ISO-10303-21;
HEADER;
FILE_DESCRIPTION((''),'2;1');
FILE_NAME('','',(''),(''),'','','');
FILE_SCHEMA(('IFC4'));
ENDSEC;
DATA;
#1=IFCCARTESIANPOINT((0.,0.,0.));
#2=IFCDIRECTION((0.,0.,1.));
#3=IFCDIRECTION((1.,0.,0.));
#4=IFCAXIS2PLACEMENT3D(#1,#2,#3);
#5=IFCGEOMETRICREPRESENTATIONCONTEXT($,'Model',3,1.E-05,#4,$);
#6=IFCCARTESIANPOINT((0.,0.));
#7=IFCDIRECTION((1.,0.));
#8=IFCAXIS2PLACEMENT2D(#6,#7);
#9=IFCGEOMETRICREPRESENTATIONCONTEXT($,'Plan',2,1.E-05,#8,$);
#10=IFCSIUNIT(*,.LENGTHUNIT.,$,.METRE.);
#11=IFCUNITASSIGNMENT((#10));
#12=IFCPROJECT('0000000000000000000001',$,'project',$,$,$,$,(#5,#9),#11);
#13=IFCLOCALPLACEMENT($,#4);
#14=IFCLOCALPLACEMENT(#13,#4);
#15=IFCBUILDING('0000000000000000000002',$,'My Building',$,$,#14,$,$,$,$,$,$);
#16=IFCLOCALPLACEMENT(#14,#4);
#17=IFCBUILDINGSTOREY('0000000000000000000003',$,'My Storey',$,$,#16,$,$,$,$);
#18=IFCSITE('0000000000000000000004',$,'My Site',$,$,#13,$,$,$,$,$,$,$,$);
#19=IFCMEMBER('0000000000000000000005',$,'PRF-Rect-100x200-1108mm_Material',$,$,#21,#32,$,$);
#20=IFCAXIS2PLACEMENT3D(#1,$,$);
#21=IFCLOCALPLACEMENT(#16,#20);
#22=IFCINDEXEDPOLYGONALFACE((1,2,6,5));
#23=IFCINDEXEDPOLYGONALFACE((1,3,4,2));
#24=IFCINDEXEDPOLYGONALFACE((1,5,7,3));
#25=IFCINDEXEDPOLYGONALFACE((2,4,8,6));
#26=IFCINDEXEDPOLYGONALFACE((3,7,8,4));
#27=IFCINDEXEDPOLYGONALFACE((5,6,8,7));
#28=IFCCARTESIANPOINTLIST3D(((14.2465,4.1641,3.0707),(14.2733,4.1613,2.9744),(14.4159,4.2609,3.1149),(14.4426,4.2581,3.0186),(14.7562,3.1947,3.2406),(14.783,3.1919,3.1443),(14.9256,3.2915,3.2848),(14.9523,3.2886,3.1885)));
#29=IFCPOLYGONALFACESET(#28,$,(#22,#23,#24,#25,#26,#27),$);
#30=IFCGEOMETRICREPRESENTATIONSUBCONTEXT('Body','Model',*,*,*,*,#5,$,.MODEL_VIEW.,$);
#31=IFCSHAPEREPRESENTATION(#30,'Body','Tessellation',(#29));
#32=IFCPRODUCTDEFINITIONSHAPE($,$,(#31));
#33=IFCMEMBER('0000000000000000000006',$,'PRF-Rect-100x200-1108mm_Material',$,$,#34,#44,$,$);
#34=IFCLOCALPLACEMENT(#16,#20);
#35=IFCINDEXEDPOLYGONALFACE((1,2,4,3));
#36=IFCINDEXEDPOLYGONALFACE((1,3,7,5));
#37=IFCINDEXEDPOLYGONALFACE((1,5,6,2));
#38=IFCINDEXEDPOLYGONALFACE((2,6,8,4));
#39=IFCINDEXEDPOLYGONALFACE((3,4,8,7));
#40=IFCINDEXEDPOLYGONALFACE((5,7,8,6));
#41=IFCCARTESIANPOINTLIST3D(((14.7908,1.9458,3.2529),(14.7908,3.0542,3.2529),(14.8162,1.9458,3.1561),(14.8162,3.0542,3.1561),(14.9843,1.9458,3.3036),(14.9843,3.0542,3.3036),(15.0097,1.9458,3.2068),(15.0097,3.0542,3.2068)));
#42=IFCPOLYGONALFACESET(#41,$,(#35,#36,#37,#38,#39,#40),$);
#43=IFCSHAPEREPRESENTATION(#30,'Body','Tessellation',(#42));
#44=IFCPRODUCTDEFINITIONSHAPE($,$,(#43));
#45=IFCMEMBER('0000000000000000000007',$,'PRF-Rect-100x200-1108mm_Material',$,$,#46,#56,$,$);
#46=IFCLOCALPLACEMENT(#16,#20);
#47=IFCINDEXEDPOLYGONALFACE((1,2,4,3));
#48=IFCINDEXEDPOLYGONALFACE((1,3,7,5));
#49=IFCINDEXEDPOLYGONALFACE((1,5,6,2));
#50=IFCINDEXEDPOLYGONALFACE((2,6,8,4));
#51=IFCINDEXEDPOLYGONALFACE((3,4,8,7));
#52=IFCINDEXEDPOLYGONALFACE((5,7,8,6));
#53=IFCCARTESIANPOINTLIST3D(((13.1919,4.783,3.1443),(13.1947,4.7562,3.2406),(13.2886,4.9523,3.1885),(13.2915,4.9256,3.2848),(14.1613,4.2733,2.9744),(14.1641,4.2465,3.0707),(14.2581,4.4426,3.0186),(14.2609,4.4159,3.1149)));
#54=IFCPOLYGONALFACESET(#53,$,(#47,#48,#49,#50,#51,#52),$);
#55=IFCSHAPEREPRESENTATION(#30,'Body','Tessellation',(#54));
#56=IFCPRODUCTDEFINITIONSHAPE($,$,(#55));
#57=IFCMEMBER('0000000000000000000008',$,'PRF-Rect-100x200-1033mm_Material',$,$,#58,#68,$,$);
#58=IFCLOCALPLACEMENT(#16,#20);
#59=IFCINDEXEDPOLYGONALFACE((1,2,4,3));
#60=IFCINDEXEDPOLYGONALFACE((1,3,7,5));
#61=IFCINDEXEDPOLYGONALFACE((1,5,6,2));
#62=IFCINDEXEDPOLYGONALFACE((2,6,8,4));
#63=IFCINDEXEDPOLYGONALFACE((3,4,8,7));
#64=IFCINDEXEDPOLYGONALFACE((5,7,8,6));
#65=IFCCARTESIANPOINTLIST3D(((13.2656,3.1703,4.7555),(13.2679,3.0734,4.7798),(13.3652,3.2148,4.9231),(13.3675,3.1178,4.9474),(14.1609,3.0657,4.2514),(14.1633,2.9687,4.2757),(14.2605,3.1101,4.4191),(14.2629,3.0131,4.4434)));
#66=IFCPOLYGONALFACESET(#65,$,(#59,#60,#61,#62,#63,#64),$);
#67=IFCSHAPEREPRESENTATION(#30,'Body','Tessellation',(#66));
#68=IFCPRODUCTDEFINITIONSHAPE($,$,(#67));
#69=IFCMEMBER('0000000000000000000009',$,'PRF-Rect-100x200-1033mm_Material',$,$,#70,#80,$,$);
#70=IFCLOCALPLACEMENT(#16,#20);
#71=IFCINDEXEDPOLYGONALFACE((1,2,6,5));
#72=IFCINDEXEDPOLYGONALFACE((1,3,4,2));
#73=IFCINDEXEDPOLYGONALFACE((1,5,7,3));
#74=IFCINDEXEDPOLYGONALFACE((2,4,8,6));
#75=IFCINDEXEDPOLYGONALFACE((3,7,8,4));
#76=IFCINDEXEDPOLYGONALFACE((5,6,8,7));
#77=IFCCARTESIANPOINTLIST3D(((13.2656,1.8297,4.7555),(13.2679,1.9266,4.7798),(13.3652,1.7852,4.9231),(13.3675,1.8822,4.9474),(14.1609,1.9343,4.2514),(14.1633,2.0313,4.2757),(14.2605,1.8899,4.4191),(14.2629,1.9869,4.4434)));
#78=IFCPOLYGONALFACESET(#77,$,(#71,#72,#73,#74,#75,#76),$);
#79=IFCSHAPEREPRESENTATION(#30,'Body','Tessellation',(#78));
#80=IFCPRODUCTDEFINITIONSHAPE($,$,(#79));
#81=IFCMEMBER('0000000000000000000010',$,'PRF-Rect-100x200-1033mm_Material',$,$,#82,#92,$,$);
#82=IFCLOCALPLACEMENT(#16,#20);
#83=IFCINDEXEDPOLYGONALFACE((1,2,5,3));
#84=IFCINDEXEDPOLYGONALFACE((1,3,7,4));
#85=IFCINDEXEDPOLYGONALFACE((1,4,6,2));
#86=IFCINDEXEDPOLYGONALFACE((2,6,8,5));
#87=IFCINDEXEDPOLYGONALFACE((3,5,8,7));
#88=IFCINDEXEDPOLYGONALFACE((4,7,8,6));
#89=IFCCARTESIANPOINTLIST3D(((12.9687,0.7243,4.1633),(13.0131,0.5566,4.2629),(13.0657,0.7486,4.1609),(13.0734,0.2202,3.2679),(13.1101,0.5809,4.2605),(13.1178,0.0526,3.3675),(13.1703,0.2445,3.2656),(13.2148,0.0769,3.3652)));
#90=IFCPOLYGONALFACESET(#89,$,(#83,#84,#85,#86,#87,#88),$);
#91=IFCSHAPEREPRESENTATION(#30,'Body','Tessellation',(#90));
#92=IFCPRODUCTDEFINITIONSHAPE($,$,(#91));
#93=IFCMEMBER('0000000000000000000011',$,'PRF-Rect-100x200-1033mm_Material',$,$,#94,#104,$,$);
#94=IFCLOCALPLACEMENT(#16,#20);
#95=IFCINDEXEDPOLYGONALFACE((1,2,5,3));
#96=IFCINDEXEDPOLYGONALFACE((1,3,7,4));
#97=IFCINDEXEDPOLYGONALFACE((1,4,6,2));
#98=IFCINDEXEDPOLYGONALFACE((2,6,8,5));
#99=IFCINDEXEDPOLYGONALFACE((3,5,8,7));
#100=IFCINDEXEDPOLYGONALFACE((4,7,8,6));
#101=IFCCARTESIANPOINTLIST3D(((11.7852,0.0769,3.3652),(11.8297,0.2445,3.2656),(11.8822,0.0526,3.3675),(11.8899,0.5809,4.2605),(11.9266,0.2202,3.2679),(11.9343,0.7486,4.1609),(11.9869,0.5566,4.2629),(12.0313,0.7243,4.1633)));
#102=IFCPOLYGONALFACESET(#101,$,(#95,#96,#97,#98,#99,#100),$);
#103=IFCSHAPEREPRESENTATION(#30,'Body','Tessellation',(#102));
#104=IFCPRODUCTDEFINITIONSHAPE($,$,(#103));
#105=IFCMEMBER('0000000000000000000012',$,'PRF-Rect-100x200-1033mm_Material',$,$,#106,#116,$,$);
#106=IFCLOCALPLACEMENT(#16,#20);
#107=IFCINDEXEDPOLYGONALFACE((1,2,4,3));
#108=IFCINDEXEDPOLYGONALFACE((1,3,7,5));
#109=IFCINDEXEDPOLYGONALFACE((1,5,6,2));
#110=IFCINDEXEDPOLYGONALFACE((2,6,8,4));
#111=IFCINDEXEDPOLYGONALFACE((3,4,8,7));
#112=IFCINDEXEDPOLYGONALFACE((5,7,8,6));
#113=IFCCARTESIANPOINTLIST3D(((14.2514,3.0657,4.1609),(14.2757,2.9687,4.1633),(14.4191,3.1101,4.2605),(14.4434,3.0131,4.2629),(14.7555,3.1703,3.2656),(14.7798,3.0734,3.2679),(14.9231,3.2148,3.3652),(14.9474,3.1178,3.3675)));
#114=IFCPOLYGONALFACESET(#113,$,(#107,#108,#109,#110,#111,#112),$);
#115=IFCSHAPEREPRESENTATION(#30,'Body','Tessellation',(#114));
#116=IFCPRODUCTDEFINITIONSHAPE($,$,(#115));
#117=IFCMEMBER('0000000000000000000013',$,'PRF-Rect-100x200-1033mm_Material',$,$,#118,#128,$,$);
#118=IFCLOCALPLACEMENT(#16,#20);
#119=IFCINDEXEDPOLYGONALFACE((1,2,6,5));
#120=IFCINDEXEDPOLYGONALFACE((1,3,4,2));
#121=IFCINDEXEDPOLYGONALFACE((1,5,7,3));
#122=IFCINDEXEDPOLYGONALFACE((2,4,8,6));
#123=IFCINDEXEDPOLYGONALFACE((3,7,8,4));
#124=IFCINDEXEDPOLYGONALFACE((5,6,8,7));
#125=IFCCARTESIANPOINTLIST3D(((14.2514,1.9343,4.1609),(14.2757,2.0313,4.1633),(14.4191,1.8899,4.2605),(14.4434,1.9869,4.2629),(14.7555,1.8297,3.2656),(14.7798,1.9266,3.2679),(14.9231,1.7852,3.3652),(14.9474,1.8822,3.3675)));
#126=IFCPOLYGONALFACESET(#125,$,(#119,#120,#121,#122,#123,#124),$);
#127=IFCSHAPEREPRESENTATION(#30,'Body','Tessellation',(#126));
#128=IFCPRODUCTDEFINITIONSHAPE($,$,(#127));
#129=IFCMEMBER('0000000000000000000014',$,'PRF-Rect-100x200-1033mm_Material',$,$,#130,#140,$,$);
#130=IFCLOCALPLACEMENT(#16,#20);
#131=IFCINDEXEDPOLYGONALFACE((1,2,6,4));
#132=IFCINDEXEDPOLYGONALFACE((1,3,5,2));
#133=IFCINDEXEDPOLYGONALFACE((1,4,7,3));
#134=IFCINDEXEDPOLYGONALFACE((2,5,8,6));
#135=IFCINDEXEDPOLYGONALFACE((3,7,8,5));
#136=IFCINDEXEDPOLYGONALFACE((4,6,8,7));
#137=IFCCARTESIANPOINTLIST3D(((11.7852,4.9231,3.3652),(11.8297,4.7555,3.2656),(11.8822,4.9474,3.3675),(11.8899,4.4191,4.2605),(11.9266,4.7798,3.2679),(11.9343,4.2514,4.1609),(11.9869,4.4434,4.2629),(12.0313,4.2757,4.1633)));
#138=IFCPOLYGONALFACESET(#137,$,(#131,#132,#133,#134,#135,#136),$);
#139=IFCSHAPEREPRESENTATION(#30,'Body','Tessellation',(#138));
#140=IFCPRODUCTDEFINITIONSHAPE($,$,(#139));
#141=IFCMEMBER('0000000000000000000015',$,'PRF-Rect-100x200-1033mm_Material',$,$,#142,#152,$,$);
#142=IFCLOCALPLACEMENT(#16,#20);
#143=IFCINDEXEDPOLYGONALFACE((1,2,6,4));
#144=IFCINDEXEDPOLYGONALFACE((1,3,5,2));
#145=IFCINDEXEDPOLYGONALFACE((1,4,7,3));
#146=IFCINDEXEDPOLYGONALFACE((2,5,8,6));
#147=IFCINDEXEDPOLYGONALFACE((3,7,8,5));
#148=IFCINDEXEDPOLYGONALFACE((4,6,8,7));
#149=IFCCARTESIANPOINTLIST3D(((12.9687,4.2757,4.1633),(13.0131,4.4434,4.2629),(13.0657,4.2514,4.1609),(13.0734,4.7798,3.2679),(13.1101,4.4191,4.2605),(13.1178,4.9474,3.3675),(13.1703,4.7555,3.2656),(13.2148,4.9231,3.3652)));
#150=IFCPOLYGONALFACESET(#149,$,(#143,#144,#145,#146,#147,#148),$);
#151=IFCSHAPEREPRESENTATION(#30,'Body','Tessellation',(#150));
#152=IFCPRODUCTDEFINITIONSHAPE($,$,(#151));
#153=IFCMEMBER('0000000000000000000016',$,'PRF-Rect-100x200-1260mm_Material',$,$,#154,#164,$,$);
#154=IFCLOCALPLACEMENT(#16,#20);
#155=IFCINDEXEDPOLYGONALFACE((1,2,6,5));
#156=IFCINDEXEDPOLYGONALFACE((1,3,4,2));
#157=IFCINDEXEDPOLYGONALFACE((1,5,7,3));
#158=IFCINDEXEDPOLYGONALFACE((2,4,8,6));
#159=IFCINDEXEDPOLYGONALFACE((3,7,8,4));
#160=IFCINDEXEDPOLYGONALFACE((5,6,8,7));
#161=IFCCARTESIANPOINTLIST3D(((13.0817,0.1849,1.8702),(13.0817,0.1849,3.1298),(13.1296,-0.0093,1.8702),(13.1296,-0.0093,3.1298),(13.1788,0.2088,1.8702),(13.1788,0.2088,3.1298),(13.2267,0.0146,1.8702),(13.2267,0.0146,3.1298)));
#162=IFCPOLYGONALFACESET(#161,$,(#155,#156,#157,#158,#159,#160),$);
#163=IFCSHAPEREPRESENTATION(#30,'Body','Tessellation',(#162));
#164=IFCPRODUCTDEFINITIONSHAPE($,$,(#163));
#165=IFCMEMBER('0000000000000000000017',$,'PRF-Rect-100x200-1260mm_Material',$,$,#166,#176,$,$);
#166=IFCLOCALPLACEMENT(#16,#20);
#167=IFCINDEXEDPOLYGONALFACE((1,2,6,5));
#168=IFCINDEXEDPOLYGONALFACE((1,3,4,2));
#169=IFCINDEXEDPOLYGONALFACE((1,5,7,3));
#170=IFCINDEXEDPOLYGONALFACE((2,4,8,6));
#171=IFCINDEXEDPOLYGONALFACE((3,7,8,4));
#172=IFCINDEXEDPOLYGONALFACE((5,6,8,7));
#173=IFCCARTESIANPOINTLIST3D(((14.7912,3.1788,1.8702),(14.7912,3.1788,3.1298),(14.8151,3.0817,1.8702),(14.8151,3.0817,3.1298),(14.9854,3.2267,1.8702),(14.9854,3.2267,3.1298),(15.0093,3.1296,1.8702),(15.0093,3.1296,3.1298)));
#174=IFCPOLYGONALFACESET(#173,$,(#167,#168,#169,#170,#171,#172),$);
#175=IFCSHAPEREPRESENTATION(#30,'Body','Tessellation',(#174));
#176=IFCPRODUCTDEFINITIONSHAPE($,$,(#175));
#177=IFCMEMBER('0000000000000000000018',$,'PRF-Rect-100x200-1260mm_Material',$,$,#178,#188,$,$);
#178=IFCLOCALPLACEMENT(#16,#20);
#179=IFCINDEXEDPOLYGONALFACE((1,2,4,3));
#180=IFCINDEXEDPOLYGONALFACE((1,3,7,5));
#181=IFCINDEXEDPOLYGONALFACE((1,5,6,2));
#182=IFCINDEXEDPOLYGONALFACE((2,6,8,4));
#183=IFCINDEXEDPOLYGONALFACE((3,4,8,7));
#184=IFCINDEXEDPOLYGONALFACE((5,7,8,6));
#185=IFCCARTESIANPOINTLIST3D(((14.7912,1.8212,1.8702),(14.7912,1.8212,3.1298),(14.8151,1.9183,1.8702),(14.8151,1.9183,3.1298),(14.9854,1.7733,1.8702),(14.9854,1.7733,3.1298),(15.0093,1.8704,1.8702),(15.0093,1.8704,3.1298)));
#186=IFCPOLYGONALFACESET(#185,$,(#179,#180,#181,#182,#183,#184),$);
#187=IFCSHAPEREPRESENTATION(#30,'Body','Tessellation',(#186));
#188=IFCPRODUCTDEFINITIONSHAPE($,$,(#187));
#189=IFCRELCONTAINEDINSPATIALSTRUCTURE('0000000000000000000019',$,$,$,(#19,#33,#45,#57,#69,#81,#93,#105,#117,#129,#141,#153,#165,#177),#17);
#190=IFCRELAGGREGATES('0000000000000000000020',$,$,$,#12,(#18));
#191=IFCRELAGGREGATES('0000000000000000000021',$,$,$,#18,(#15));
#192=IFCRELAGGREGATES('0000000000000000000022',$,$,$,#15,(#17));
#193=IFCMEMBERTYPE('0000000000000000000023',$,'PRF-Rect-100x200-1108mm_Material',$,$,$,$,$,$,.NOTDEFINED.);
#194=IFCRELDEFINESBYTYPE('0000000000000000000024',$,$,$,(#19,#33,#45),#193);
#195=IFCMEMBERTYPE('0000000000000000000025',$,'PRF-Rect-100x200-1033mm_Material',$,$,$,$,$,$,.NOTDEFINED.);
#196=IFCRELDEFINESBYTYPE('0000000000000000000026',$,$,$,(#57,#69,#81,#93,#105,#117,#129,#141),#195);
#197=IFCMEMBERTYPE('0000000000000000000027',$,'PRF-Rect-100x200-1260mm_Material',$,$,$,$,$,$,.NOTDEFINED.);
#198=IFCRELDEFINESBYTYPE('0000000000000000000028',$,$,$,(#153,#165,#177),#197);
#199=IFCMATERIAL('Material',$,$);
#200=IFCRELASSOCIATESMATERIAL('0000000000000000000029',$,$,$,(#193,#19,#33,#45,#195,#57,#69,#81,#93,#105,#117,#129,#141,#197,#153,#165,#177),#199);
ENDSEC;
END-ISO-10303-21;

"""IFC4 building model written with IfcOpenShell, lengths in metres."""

from ifc_helpers import new_model, si_unit, frame, origin, origin_with_axes, origin_2d_with_axis, place, context, subcontext, project, spatial, rectangle, extrude, material, material_profile, profile_set, profile_usage, type_object, element, save


model = new_model("IFC4")

# Units and contexts
model_context = context("Model", 3, precision=1e-05, world=origin_with_axes())
plan_context = context("Plan", 2, precision=1e-05, world=origin_2d_with_axis())
body_context = subcontext(model_context, "Body", "Model", "MODEL_VIEW")
ifc_project = project(units=[si_unit("LENGTHUNIT", "METRE")], contexts=[model_context, plan_context])

# Site, building, storey
site_placement = place(None, origin_with_axes())
site = spatial("IfcSite", under=ifc_project, at=site_placement, Name="My Site")
building_placement = place(site_placement, origin_with_axes())
building = spatial("IfcBuilding", under=site, at=building_placement, Name="My Building")
storey_placement = place(building_placement, origin_with_axes())
storey = spatial("IfcBuildingStorey", under=building, at=storey_placement, Name="My Storey")

# Members
ifc_material = material(Name="Material")
ifc_material_profile_1 = material_profile(ifc_material, rectangle(XDim=0.1, YDim=0.2))
ifc_profile_set_1 = profile_set([ifc_material_profile_1], Name="PRF-Rect-100x200-1108mm_Material")
member_type_1 = type_object("IfcMemberType", Name="PRF-Rect-100x200-1108mm_Material", PredefinedType="NOTDEFINED", material=ifc_profile_set_1)
ifc_profile_usage_1 = profile_usage(ifc_profile_set_1, cardinal=5)
member_1_placement = place(storey_placement, frame((14.3446, 4.2111, 3.0446), z_axis=(0.459849, -0.874668, 0.153283), x_axis=(0.2675, -0.028153, -0.963147)))
element("IfcMember", 1, at=member_1_placement, inside=storey, type_object=member_type_1, material=ifc_profile_usage_1, Name="PRF-Rect-100x200-1108mm_Material", context=body_context, shape_type="SweptSolid", body=[
    extrude(rectangle(XDim=0.1, YDim=0.2), origin(), (0.0, 0.0, 1.0), 1.1084),
])
ifc_profile_usage_2 = profile_usage(ifc_profile_set_1, cardinal=5)
member_2_placement = place(storey_placement, frame((14.9002, 3.0542, 3.2298), z_axis=(0.0, -1.0, 0.0), x_axis=(0.253569, 0.0, -0.967317)))
element("IfcMember", 2, at=member_2_placement, inside=storey, type_object=member_type_1, material=ifc_profile_usage_2, Name="PRF-Rect-100x200-1108mm_Material", context=body_context, shape_type="SweptSolid", body=[
    extrude(rectangle(XDim=0.1, YDim=0.2), origin(), (0.0, 0.0, 1.0), 1.1084),
])
ifc_profile_usage_3 = profile_usage(ifc_profile_set_1, cardinal=5)
member_3_placement = place(storey_placement, frame((13.2417, 4.8543, 3.2145), z_axis=(0.874668, -0.459849, -0.153283), x_axis=(-0.028153, 0.2675, -0.963147)))
element("IfcMember", 3, at=member_3_placement, inside=storey, type_object=member_type_1, material=ifc_profile_usage_3, Name="PRF-Rect-100x200-1108mm_Material", context=body_context, shape_type="SweptSolid", body=[
    extrude(rectangle(XDim=0.1, YDim=0.2), origin(), (0.0, 0.0, 1.0), 1.1084),
])
ifc_material_profile_2 = material_profile(ifc_material, rectangle(XDim=0.1, YDim=0.2))
ifc_profile_set_2 = profile_set([ifc_material_profile_2], Name="PRF-Rect-100x200-1033mm_Material")
ifc_profile_usage_4 = profile_usage(ifc_profile_set_2, cardinal=5)
member_type_2 = type_object("IfcMemberType", Name="PRF-Rect-100x200-1033mm_Material", PredefinedType="NOTDEFINED", material=ifc_profile_set_2)
member_4_placement = place(storey_placement, frame((13.3165, 3.1441, 4.8514), z_axis=(0.866922, -0.101314, -0.488039), x_axis=(-0.023454, 0.969748, -0.242978)))
element("IfcMember", 4, at=member_4_placement, inside=storey, type_object=member_type_2, material=ifc_profile_usage_4, Name="PRF-Rect-100x200-1033mm_Material", context=body_context, shape_type="SweptSolid", body=[
    extrude(rectangle(XDim=0.1, YDim=0.2), origin(), (0.0, 0.0, 1.0), 1.0328),
])
ifc_profile_usage_5 = profile_usage(ifc_profile_set_2, cardinal=5)
member_5_placement = place(storey_placement, frame((13.3165, 1.8559, 4.8514), z_axis=(0.866922, 0.101314, -0.488039), x_axis=(0.023454, 0.969748, 0.242978)))
element("IfcMember", 5, at=member_5_placement, inside=storey, type_object=member_type_2, material=ifc_profile_usage_5, Name="PRF-Rect-100x200-1033mm_Material", context=body_context, shape_type="SweptSolid", body=[
    extrude(rectangle(XDim=0.1, YDim=0.2), origin(), (0.0, 0.0, 1.0), 1.0328),
])
ifc_profile_usage_6 = profile_usage(ifc_profile_set_2, cardinal=5)
member_6_placement = place(storey_placement, frame((13.0394, 0.6526, 4.2119), z_axis=(0.101315, -0.488039, -0.866922), x_axis=(0.969748, 0.242978, -0.023454)))
element("IfcMember", 6, at=member_6_placement, inside=storey, type_object=member_type_2, material=ifc_profile_usage_6, Name="PRF-Rect-100x200-1033mm_Material", context=body_context, shape_type="SweptSolid", body=[
    extrude(rectangle(XDim=0.1, YDim=0.2), origin(), (0.0, 0.0, 1.0), 1.0328),
])
ifc_profile_usage_7 = profile_usage(ifc_profile_set_2, cardinal=5)
member_7_placement = place(storey_placement, frame((11.9606, 0.6526, 4.2119), z_axis=(-0.101315, -0.488039, -0.866922), x_axis=(0.969748, -0.242978, 0.023454)))
element("IfcMember", 7, at=member_7_placement, inside=storey, type_object=member_type_2, material=ifc_profile_usage_7, Name="PRF-Rect-100x200-1033mm_Material", context=body_context, shape_type="SweptSolid", body=[
    extrude(rectangle(XDim=0.1, YDim=0.2), origin(), (0.0, 0.0, 1.0), 1.0328),
])
ifc_profile_usage_8 = profile_usage(ifc_profile_set_2, cardinal=5)
member_8_placement = place(storey_placement, frame((14.3474, 3.0394, 4.2119), z_axis=(0.488039, 0.101314, -0.866922), x_axis=(-0.242978, 0.969748, -0.023454)))
element("IfcMember", 8, at=member_8_placement, inside=storey, type_object=member_type_2, material=ifc_profile_usage_8, Name="PRF-Rect-100x200-1033mm_Material", context=body_context, shape_type="SweptSolid", body=[
    extrude(rectangle(XDim=0.1, YDim=0.2), origin(), (0.0, 0.0, 1.0), 1.0328),
])
ifc_profile_usage_9 = profile_usage(ifc_profile_set_2, cardinal=5)
member_9_placement = place(storey_placement, frame((14.3474, 1.9606, 4.2119), z_axis=(0.488039, -0.101314, -0.866922), x_axis=(0.242978, 0.969748, 0.023454)))
element("IfcMember", 9, at=member_9_placement, inside=storey, type_object=member_type_2, material=ifc_profile_usage_9, Name="PRF-Rect-100x200-1033mm_Material", context=body_context, shape_type="SweptSolid", body=[
    extrude(rectangle(XDim=0.1, YDim=0.2), origin(), (0.0, 0.0, 1.0), 1.0328),
])
ifc_profile_usage_10 = profile_usage(ifc_profile_set_2, cardinal=5)
member_10_placement = place(storey_placement, frame((11.9606, 4.3474, 4.2119), z_axis=(-0.101315, 0.488039, -0.866922), x_axis=(-0.969748, -0.242978, -0.023454)))
element("IfcMember", 10, at=member_10_placement, inside=storey, type_object=member_type_2, material=ifc_profile_usage_10, Name="PRF-Rect-100x200-1033mm_Material", context=body_context, shape_type="SweptSolid", body=[
    extrude(rectangle(XDim=0.1, YDim=0.2), origin(), (0.0, 0.0, 1.0), 1.0328),
])
ifc_profile_usage_11 = profile_usage(ifc_profile_set_2, cardinal=5)
member_11_placement = place(storey_placement, frame((13.0394, 4.3474, 4.2119), z_axis=(0.101315, 0.488039, -0.866922), x_axis=(-0.969748, 0.242978, 0.023454)))
element("IfcMember", 11, at=member_11_placement, inside=storey, type_object=member_type_2, material=ifc_profile_usage_11, Name="PRF-Rect-100x200-1033mm_Material", context=body_context, shape_type="SweptSolid", body=[
    extrude(rectangle(XDim=0.1, YDim=0.2), origin(), (0.0, 0.0, 1.0), 1.0328),
])
ifc_material_profile_3 = material_profile(ifc_material, rectangle(XDim=0.1, YDim=0.2))
ifc_profile_set_3 = profile_set([ifc_material_profile_3], Name="PRF-Rect-100x200-1260mm_Material")
ifc_profile_usage_12 = profile_usage(ifc_profile_set_3, cardinal=5)
member_type_3 = type_object("IfcMemberType", Name="PRF-Rect-100x200-1260mm_Material", PredefinedType="NOTDEFINED", material=ifc_profile_set_3)
member_12_placement = place(storey_placement, frame((13.1542, 0.0998, 3.1298), z_axis=(-0.000001, 0.0, -1.0), x_axis=(0.970857, 0.239658, -0.000001)))
element("IfcMember", 12, at=member_12_placement, inside=storey, type_object=member_type_3, material=ifc_profile_usage_12, Name="PRF-Rect-100x200-1260mm_Material", context=body_context, shape_type="SweptSolid", body=[
    extrude(rectangle(XDim=0.1, YDim=0.2), origin(), (0.0, 0.0, 1.0), 1.2597),
])
ifc_profile_usage_13 = profile_usage(ifc_profile_set_3, cardinal=5)
member_13_placement = place(storey_placement, frame((14.9002, 3.1542, 3.1298), z_axis=(0.0, 0.0, -1.0), x_axis=(-0.239658, 0.970857, 0.0)))
element("IfcMember", 13, at=member_13_placement, inside=storey, type_object=member_type_3, material=ifc_profile_usage_13, Name="PRF-Rect-100x200-1260mm_Material", context=body_context, shape_type="SweptSolid", body=[
    extrude(rectangle(XDim=0.1, YDim=0.2), origin(), (0.0, 0.0, 1.0), 1.2597),
])
ifc_profile_usage_14 = profile_usage(ifc_profile_set_3, cardinal=5)
member_14_placement = place(storey_placement, frame((14.9002, 1.8458, 3.1298), z_axis=(0.0, 0.0, -1.0), x_axis=(0.239658, 0.970857, 0.0)))
element("IfcMember", 14, at=member_14_placement, inside=storey, type_object=member_type_3, material=ifc_profile_usage_14, Name="PRF-Rect-100x200-1260mm_Material", context=body_context, shape_type="SweptSolid", body=[
    extrude(rectangle(XDim=0.1, YDim=0.2), origin(), (0.0, 0.0, 1.0), 1.2597),
])

save(model, "model.ifc")
